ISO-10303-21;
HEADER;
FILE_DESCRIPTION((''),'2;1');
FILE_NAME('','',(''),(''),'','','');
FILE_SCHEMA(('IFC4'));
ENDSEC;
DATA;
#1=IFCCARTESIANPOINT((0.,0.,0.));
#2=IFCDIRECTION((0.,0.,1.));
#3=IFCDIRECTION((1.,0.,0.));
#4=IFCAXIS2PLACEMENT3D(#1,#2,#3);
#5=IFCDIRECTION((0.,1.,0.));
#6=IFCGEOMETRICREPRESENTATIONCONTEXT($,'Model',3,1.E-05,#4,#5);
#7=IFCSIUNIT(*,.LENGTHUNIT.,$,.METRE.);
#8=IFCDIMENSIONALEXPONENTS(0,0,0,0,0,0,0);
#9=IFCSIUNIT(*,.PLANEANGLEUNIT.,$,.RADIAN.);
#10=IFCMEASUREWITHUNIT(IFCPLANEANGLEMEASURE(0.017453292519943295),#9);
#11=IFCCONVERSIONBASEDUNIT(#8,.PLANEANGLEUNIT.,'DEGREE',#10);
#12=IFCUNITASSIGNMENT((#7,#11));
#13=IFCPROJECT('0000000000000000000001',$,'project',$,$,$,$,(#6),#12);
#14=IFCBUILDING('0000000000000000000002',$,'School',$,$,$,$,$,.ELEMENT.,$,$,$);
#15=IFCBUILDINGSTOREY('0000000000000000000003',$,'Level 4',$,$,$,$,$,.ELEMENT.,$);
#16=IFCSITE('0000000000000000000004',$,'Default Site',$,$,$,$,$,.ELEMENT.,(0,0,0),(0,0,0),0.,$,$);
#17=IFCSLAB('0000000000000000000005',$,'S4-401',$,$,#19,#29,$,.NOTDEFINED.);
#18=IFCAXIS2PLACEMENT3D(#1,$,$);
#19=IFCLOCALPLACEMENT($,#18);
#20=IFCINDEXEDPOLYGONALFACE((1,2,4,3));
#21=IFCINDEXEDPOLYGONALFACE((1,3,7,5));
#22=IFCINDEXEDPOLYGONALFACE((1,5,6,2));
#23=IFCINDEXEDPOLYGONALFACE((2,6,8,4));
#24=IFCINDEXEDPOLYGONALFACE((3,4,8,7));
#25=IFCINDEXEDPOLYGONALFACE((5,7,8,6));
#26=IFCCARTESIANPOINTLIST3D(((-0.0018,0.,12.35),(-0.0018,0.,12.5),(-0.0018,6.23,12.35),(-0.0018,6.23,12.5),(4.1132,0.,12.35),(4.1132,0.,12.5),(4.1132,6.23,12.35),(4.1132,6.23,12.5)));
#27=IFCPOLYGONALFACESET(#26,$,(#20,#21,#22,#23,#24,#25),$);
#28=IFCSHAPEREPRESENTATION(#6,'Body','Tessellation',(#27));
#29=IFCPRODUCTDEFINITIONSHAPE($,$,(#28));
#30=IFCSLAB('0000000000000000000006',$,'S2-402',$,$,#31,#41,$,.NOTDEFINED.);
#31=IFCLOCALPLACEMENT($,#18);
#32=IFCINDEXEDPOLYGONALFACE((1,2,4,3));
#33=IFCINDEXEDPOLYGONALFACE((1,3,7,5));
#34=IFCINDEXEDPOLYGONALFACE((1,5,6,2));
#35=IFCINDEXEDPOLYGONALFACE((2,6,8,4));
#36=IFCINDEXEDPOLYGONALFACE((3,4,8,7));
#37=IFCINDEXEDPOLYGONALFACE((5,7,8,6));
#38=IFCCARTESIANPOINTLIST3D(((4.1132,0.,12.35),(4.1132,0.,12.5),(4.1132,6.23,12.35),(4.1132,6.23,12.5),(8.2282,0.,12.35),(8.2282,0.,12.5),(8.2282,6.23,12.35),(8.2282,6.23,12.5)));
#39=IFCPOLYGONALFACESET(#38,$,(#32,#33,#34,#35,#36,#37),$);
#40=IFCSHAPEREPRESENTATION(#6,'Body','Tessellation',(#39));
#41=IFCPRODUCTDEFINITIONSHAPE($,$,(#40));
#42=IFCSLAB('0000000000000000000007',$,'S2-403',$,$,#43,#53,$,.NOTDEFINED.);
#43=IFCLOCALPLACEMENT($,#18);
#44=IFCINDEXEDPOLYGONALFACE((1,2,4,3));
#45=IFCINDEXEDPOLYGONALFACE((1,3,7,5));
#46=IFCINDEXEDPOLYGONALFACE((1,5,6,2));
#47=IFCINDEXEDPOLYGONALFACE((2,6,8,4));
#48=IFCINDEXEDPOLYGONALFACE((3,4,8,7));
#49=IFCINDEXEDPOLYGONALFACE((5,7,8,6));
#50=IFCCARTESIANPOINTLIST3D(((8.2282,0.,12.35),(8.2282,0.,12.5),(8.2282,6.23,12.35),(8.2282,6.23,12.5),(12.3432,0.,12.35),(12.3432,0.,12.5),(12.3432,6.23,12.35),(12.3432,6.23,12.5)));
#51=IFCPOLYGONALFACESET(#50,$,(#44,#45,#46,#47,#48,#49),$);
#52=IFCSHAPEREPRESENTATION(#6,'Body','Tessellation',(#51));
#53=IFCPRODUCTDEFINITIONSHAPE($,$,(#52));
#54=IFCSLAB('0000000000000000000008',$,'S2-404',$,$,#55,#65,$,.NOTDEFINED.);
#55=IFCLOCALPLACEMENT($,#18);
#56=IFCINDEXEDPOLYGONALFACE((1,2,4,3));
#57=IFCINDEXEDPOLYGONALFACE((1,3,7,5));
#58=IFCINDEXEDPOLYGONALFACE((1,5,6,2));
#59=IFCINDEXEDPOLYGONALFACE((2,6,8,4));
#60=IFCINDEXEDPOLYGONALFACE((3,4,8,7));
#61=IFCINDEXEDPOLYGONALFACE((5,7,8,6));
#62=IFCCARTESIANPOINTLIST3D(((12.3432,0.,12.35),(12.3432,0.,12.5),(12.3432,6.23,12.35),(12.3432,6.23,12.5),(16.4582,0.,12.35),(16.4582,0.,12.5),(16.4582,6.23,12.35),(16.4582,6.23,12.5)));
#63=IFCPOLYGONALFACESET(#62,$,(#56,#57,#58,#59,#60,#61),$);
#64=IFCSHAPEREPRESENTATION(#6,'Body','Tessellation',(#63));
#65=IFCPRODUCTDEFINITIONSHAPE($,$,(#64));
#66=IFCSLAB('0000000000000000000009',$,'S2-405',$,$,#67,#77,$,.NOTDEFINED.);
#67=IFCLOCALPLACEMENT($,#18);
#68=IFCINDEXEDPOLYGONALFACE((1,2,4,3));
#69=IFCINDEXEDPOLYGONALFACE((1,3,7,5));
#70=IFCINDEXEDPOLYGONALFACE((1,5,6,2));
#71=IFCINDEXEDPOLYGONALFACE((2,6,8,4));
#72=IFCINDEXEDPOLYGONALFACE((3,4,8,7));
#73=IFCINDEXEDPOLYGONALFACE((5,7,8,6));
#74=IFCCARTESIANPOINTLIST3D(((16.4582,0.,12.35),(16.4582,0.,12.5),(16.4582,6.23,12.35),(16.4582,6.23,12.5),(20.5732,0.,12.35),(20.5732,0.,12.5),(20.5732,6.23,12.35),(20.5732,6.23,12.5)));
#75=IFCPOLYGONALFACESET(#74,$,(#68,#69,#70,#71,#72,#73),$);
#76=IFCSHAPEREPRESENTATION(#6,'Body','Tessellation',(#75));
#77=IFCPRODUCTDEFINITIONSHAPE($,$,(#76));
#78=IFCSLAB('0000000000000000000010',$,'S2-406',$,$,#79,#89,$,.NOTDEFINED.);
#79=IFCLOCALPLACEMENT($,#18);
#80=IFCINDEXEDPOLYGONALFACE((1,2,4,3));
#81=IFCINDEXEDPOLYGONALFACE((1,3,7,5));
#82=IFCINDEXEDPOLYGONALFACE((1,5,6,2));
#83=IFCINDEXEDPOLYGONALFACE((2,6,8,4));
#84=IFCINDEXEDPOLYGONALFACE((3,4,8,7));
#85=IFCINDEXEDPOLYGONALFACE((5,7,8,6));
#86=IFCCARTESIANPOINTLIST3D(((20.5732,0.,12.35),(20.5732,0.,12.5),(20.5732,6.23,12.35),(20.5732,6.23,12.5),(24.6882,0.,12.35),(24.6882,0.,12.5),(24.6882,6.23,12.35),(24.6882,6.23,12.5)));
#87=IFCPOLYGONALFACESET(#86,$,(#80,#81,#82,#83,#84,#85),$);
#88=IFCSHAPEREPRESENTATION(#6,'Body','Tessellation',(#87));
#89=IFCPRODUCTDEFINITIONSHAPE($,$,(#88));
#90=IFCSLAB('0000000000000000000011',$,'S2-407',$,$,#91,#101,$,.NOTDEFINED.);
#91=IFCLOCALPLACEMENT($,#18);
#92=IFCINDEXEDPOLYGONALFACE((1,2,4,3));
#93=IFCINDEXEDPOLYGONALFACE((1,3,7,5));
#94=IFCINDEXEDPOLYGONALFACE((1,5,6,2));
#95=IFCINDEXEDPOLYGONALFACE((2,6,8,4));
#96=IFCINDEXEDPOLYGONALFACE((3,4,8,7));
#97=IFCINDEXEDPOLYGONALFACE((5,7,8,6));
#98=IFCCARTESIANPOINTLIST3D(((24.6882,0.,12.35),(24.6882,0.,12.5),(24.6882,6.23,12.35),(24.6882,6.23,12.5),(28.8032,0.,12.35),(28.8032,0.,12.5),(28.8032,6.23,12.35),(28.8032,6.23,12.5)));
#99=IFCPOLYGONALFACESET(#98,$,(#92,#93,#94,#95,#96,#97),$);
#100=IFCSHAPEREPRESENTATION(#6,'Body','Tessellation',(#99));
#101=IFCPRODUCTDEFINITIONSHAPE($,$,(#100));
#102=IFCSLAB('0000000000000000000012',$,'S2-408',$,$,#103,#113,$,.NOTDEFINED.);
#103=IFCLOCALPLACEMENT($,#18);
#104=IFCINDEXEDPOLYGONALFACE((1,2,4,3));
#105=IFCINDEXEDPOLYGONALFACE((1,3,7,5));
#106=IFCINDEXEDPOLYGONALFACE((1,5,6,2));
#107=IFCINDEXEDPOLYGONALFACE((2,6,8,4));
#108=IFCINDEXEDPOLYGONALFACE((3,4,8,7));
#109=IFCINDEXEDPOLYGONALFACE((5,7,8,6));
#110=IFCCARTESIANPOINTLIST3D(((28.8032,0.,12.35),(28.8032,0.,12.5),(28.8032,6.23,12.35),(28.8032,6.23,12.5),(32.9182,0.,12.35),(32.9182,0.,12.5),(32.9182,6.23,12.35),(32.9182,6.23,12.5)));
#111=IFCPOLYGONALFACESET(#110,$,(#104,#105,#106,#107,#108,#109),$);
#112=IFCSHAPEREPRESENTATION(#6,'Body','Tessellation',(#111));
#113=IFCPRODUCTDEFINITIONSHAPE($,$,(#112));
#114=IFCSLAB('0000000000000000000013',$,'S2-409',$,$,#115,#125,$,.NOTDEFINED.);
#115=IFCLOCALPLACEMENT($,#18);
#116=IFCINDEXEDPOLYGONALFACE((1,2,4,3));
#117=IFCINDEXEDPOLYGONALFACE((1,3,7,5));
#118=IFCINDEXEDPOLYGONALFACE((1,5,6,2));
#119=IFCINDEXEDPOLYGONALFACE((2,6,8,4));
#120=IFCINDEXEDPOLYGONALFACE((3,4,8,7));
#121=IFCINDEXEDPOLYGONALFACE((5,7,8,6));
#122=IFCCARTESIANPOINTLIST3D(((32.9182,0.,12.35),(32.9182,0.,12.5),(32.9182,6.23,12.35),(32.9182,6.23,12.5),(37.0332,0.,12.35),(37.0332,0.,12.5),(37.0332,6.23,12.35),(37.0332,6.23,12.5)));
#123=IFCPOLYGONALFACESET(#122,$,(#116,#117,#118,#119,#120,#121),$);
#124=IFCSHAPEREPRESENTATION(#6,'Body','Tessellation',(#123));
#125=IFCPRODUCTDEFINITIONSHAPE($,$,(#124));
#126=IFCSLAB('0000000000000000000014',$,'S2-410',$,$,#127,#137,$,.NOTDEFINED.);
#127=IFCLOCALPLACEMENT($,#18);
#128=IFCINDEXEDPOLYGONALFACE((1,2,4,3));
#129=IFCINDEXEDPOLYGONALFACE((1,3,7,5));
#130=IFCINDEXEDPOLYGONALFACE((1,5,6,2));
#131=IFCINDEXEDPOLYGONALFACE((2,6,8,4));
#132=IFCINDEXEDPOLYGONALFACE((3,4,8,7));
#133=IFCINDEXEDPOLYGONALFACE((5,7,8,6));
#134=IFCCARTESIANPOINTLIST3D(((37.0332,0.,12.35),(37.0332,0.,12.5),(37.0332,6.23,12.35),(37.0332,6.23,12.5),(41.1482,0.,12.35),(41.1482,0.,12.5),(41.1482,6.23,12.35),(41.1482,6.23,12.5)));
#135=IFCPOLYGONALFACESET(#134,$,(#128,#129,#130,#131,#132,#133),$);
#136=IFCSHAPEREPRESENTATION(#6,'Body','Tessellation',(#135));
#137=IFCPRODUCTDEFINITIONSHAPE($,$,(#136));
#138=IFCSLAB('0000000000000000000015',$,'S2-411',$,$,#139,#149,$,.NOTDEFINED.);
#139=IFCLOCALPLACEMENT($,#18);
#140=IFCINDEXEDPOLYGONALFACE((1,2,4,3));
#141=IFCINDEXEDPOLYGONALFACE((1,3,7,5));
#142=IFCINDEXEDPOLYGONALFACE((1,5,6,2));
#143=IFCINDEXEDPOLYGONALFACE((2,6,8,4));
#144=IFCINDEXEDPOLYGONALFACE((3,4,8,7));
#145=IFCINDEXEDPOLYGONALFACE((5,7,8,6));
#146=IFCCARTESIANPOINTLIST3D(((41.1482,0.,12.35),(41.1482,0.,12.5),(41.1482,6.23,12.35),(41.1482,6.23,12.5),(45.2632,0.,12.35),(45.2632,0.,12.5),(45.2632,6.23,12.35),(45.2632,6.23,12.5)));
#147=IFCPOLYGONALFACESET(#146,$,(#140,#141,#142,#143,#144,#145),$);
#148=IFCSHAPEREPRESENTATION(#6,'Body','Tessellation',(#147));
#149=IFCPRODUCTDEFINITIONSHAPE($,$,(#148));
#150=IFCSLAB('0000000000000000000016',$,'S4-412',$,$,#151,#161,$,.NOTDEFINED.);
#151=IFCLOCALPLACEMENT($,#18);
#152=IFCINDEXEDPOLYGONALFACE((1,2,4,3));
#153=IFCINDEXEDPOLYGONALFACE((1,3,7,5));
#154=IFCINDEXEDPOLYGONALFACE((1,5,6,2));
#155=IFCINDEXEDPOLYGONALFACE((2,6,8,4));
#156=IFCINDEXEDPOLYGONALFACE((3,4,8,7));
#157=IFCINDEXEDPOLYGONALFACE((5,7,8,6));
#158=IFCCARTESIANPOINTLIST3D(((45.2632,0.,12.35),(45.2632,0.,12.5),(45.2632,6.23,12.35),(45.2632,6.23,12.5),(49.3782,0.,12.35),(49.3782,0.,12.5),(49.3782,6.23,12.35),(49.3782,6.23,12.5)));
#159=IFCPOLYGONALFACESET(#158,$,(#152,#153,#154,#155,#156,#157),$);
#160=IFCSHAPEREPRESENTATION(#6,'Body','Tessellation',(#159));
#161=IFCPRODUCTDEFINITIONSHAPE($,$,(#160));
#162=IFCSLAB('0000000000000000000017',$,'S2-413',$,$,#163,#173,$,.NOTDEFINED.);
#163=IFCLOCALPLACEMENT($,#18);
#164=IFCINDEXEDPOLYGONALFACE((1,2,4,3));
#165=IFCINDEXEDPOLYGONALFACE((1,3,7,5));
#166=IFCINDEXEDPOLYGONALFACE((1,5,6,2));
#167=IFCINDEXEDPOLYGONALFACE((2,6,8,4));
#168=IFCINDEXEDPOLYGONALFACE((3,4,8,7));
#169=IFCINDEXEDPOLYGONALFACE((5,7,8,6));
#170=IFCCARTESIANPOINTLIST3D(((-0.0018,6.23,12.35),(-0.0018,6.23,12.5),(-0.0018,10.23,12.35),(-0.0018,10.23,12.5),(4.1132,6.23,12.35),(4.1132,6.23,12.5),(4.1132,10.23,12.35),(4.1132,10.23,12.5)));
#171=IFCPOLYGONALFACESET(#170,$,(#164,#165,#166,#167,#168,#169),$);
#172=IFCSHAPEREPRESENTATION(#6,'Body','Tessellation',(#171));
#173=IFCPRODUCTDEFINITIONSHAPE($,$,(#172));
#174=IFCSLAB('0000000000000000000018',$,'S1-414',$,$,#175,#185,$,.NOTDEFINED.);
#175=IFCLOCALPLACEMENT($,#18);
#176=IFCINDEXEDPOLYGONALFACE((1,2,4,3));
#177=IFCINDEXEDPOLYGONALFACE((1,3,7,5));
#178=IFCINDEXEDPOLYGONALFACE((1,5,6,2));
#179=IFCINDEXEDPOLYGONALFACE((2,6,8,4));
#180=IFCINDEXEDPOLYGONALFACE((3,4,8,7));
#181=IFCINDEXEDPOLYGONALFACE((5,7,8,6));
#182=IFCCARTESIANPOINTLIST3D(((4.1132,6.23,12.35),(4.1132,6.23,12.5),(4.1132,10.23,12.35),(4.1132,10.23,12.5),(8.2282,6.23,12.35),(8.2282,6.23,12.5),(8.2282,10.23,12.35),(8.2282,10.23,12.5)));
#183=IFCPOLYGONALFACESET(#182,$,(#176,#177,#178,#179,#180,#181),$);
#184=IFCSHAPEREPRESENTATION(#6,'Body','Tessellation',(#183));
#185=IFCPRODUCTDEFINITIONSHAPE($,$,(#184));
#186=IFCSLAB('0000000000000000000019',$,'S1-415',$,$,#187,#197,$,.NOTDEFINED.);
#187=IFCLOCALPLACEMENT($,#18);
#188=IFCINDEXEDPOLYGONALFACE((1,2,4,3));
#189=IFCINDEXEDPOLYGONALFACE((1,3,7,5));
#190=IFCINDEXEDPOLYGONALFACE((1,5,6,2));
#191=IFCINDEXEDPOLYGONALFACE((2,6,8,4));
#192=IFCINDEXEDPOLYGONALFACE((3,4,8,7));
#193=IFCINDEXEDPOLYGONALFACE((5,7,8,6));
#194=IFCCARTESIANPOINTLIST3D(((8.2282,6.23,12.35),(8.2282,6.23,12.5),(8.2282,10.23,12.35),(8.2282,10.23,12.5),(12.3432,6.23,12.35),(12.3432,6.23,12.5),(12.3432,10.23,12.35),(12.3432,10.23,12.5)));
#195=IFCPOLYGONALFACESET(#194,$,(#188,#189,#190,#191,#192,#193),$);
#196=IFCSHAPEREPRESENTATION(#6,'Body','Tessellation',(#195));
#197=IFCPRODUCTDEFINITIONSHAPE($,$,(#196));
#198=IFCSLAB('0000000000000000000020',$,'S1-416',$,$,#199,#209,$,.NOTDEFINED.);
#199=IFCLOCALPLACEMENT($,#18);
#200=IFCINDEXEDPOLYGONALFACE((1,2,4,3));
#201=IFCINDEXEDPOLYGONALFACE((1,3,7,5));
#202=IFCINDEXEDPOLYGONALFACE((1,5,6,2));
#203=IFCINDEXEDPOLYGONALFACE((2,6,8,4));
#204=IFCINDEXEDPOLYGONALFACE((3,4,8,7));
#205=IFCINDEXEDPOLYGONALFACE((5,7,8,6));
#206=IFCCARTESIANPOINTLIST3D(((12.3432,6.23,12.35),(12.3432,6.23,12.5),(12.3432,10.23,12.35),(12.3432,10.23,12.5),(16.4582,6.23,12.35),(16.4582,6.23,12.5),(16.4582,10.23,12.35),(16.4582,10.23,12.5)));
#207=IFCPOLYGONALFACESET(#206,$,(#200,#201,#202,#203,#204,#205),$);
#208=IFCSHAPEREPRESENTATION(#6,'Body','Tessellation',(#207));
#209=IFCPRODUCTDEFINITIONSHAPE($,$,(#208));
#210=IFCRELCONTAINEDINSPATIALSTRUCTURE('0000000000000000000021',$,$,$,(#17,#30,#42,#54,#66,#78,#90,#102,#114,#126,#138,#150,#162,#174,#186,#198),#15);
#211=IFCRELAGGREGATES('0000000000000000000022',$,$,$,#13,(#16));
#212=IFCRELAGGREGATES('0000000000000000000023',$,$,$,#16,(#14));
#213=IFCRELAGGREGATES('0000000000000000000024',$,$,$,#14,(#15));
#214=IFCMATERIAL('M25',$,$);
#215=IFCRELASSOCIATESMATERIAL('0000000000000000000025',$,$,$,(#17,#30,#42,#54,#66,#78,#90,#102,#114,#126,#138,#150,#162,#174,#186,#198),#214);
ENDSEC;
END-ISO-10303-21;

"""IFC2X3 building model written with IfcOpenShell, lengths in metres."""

from ifc_helpers import new_model, entity, si_unit, converted_unit, direction, frame, frame_2d, origin_with_axes, place, context, project, spatial, rectangle, extrude, material, element, save


model = new_model("IFC2X3")

# Units and contexts
model_context = context("Model", 3, precision=1e-05, world=origin_with_axes(), true_north=direction((0.0, 1.0, 0.0)))
ifc_project = project(units=[si_unit("LENGTHUNIT", "METRE"), converted_unit("PLANEANGLEUNIT", "DEGREE", entity("IfcPlaneAngleMeasure", 0.017453292519943295), si_unit("PLANEANGLEUNIT", "RADIAN"), dimensions=[0, 0, 0, 0, 0, 0, 0])], contexts=[model_context])

# Site, building, storey
site = spatial("IfcSite", under=ifc_project, Name="Default Site", CompositionType="ELEMENT", RefLatitude=(0, 0, 0), RefLongitude=(0, 0, 0), RefElevation=0.0)
building = spatial("IfcBuilding", under=site, Name="School", CompositionType="ELEMENT")
storey = spatial("IfcBuildingStorey", under=building, Name="Level 4", CompositionType="ELEMENT")

# Slabs
ifc_material = material(Name="M25")
placement = place(None, origin_with_axes())
element("IfcSlab", 1, at=placement, inside=storey, material=ifc_material, Name="S4-401", PredefinedType="NOTDEFINED", context=model_context, shape_type="SweptSolid", body=[
    extrude(rectangle(XDim=4.115, YDim=6.23, at=frame_2d((0.0, 0.0), x_axis=(1.0, 0.0, 0.0))), frame((2.0557, 3.115, 12.35), z_axis=(0.0, 0.0, 1.0), x_axis=(1.0, 0.0, 0.0)), (0.0, 0.0, 1.0), 0.15),
])
element("IfcSlab", 2, at=placement, inside=storey, material=ifc_material, Name="S2-402", PredefinedType="NOTDEFINED", context=model_context, shape_type="SweptSolid", body=[
    extrude(rectangle(XDim=4.115, YDim=6.23, at=frame_2d((0.0, 0.0), x_axis=(1.0, 0.0, 0.0))), frame((6.1707, 3.115, 12.35), z_axis=(0.0, 0.0, 1.0), x_axis=(1.0, 0.0, 0.0)), (0.0, 0.0, 1.0), 0.15),
])
element("IfcSlab", 3, at=placement, inside=storey, material=ifc_material, Name="S2-403", PredefinedType="NOTDEFINED", context=model_context, shape_type="SweptSolid", body=[
    extrude(rectangle(XDim=4.115, YDim=6.23, at=frame_2d((0.0, 0.0), x_axis=(1.0, 0.0, 0.0))), frame((10.2857, 3.115, 12.35), z_axis=(0.0, 0.0, 1.0), x_axis=(1.0, 0.0, 0.0)), (0.0, 0.0, 1.0), 0.15),
])
element("IfcSlab", 4, at=placement, inside=storey, material=ifc_material, Name="S2-404", PredefinedType="NOTDEFINED", context=model_context, shape_type="SweptSolid", body=[
    extrude(rectangle(XDim=4.115, YDim=6.23, at=frame_2d((0.0, 0.0), x_axis=(1.0, 0.0, 0.0))), frame((14.4007, 3.115, 12.35), z_axis=(0.0, 0.0, 1.0), x_axis=(1.0, 0.0, 0.0)), (0.0, 0.0, 1.0), 0.15),
])
element("IfcSlab", 5, at=placement, inside=storey, material=ifc_material, Name="S2-405", PredefinedType="NOTDEFINED", context=model_context, shape_type="SweptSolid", body=[
    extrude(rectangle(XDim=4.115, YDim=6.23, at=frame_2d((0.0, 0.0), x_axis=(1.0, 0.0, 0.0))), frame((18.5157, 3.115, 12.35), z_axis=(0.0, 0.0, 1.0), x_axis=(1.0, 0.0, 0.0)), (0.0, 0.0, 1.0), 0.15),
])
element("IfcSlab", 6, at=placement, inside=storey, material=ifc_material, Name="S2-406", PredefinedType="NOTDEFINED", context=model_context, shape_type="SweptSolid", body=[
    extrude(rectangle(XDim=4.115, YDim=6.23, at=frame_2d((0.0, 0.0), x_axis=(1.0, 0.0, 0.0))), frame((22.6307, 3.115, 12.35), z_axis=(0.0, 0.0, 1.0), x_axis=(1.0, 0.0, 0.0)), (0.0, 0.0, 1.0), 0.15),
])
element("IfcSlab", 7, at=placement, inside=storey, material=ifc_material, Name="S2-407", PredefinedType="NOTDEFINED", context=model_context, shape_type="SweptSolid", body=[
    extrude(rectangle(XDim=4.115, YDim=6.23, at=frame_2d((0.0, 0.0), x_axis=(1.0, 0.0, 0.0))), frame((26.7457, 3.115, 12.35), z_axis=(0.0, 0.0, 1.0), x_axis=(1.0, 0.0, 0.0)), (0.0, 0.0, 1.0), 0.15),
])
element("IfcSlab", 8, at=placement, inside=storey, material=ifc_material, Name="S2-408", PredefinedType="NOTDEFINED", context=model_context, shape_type="SweptSolid", body=[
    extrude(rectangle(XDim=4.115, YDim=6.23, at=frame_2d((0.0, 0.0), x_axis=(1.0, 0.0, 0.0))), frame((30.8607, 3.115, 12.35), z_axis=(0.0, 0.0, 1.0), x_axis=(1.0, 0.0, 0.0)), (0.0, 0.0, 1.0), 0.15),
])
element("IfcSlab", 9, at=placement, inside=storey, material=ifc_material, Name="S2-409", PredefinedType="NOTDEFINED", context=model_context, shape_type="SweptSolid", body=[
    extrude(rectangle(XDim=4.115, YDim=6.23, at=frame_2d((0.0, 0.0), x_axis=(1.0, 0.0, 0.0))), frame((34.9757, 3.115, 12.35), z_axis=(0.0, 0.0, 1.0), x_axis=(1.0, 0.0, 0.0)), (0.0, 0.0, 1.0), 0.15),
])
element("IfcSlab", 10, at=placement, inside=storey, material=ifc_material, Name="S2-410", PredefinedType="NOTDEFINED", context=model_context, shape_type="SweptSolid", body=[
    extrude(rectangle(XDim=4.115, YDim=6.23, at=frame_2d((0.0, 0.0), x_axis=(1.0, 0.0, 0.0))), frame((39.0907, 3.115, 12.35), z_axis=(0.0, 0.0, 1.0), x_axis=(1.0, 0.0, 0.0)), (0.0, 0.0, 1.0), 0.15),
])
element("IfcSlab", 11, at=placement, inside=storey, material=ifc_material, Name="S2-411", PredefinedType="NOTDEFINED", context=model_context, shape_type="SweptSolid", body=[
    extrude(rectangle(XDim=4.115, YDim=6.23, at=frame_2d((0.0, 0.0), x_axis=(1.0, 0.0, 0.0))), frame((43.2057, 3.115, 12.35), z_axis=(0.0, 0.0, 1.0), x_axis=(1.0, 0.0, 0.0)), (0.0, 0.0, 1.0), 0.15),
])
element("IfcSlab", 12, at=placement, inside=storey, material=ifc_material, Name="S4-412", PredefinedType="NOTDEFINED", context=model_context, shape_type="SweptSolid", body=[
    extrude(rectangle(XDim=4.115, YDim=6.23, at=frame_2d((0.0, 0.0), x_axis=(1.0, 0.0, 0.0))), frame((47.3207, 3.115, 12.35), z_axis=(0.0, 0.0, 1.0), x_axis=(1.0, 0.0, 0.0)), (0.0, 0.0, 1.0), 0.15),
])
element("IfcSlab", 13, at=placement, inside=storey, material=ifc_material, Name="S2-413", PredefinedType="NOTDEFINED", context=model_context, shape_type="SweptSolid", body=[
    extrude(rectangle(XDim=4.115, YDim=4.0, at=frame_2d((0.0, 0.0), x_axis=(1.0, 0.0, 0.0))), frame((2.0557, 8.23, 12.35), z_axis=(0.0, 0.0, 1.0), x_axis=(1.0, 0.0, 0.0)), (0.0, 0.0, 1.0), 0.15),
])
element("IfcSlab", 14, at=placement, inside=storey, material=ifc_material, Name="S1-414", PredefinedType="NOTDEFINED", context=model_context, shape_type="SweptSolid", body=[
    extrude(rectangle(XDim=4.115, YDim=4.0, at=frame_2d((0.0, 0.0), x_axis=(1.0, 0.0, 0.0))), frame((6.1707, 8.23, 12.35), z_axis=(0.0, 0.0, 1.0), x_axis=(1.0, 0.0, 0.0)), (0.0, 0.0, 1.0), 0.15),
])
element("IfcSlab", 15, at=placement, inside=storey, material=ifc_material, Name="S1-415", PredefinedType="NOTDEFINED", context=model_context, shape_type="SweptSolid", body=[
    extrude(rectangle(XDim=4.115, YDim=4.0, at=frame_2d((0.0, 0.0), x_axis=(1.0, 0.0, 0.0))), frame((10.2857, 8.23, 12.35), z_axis=(0.0, 0.0, 1.0), x_axis=(1.0, 0.0, 0.0)), (0.0, 0.0, 1.0), 0.15),
])
element("IfcSlab", 16, at=placement, inside=storey, material=ifc_material, Name="S1-416", PredefinedType="NOTDEFINED", context=model_context, shape_type="SweptSolid", body=[
    extrude(rectangle(XDim=4.115, YDim=4.0, at=frame_2d((0.0, 0.0), x_axis=(1.0, 0.0, 0.0))), frame((14.4007, 8.23, 12.35), z_axis=(0.0, 0.0, 1.0), x_axis=(1.0, 0.0, 0.0)), (0.0, 0.0, 1.0), 0.15),
])

save(model, "model.ifc")
